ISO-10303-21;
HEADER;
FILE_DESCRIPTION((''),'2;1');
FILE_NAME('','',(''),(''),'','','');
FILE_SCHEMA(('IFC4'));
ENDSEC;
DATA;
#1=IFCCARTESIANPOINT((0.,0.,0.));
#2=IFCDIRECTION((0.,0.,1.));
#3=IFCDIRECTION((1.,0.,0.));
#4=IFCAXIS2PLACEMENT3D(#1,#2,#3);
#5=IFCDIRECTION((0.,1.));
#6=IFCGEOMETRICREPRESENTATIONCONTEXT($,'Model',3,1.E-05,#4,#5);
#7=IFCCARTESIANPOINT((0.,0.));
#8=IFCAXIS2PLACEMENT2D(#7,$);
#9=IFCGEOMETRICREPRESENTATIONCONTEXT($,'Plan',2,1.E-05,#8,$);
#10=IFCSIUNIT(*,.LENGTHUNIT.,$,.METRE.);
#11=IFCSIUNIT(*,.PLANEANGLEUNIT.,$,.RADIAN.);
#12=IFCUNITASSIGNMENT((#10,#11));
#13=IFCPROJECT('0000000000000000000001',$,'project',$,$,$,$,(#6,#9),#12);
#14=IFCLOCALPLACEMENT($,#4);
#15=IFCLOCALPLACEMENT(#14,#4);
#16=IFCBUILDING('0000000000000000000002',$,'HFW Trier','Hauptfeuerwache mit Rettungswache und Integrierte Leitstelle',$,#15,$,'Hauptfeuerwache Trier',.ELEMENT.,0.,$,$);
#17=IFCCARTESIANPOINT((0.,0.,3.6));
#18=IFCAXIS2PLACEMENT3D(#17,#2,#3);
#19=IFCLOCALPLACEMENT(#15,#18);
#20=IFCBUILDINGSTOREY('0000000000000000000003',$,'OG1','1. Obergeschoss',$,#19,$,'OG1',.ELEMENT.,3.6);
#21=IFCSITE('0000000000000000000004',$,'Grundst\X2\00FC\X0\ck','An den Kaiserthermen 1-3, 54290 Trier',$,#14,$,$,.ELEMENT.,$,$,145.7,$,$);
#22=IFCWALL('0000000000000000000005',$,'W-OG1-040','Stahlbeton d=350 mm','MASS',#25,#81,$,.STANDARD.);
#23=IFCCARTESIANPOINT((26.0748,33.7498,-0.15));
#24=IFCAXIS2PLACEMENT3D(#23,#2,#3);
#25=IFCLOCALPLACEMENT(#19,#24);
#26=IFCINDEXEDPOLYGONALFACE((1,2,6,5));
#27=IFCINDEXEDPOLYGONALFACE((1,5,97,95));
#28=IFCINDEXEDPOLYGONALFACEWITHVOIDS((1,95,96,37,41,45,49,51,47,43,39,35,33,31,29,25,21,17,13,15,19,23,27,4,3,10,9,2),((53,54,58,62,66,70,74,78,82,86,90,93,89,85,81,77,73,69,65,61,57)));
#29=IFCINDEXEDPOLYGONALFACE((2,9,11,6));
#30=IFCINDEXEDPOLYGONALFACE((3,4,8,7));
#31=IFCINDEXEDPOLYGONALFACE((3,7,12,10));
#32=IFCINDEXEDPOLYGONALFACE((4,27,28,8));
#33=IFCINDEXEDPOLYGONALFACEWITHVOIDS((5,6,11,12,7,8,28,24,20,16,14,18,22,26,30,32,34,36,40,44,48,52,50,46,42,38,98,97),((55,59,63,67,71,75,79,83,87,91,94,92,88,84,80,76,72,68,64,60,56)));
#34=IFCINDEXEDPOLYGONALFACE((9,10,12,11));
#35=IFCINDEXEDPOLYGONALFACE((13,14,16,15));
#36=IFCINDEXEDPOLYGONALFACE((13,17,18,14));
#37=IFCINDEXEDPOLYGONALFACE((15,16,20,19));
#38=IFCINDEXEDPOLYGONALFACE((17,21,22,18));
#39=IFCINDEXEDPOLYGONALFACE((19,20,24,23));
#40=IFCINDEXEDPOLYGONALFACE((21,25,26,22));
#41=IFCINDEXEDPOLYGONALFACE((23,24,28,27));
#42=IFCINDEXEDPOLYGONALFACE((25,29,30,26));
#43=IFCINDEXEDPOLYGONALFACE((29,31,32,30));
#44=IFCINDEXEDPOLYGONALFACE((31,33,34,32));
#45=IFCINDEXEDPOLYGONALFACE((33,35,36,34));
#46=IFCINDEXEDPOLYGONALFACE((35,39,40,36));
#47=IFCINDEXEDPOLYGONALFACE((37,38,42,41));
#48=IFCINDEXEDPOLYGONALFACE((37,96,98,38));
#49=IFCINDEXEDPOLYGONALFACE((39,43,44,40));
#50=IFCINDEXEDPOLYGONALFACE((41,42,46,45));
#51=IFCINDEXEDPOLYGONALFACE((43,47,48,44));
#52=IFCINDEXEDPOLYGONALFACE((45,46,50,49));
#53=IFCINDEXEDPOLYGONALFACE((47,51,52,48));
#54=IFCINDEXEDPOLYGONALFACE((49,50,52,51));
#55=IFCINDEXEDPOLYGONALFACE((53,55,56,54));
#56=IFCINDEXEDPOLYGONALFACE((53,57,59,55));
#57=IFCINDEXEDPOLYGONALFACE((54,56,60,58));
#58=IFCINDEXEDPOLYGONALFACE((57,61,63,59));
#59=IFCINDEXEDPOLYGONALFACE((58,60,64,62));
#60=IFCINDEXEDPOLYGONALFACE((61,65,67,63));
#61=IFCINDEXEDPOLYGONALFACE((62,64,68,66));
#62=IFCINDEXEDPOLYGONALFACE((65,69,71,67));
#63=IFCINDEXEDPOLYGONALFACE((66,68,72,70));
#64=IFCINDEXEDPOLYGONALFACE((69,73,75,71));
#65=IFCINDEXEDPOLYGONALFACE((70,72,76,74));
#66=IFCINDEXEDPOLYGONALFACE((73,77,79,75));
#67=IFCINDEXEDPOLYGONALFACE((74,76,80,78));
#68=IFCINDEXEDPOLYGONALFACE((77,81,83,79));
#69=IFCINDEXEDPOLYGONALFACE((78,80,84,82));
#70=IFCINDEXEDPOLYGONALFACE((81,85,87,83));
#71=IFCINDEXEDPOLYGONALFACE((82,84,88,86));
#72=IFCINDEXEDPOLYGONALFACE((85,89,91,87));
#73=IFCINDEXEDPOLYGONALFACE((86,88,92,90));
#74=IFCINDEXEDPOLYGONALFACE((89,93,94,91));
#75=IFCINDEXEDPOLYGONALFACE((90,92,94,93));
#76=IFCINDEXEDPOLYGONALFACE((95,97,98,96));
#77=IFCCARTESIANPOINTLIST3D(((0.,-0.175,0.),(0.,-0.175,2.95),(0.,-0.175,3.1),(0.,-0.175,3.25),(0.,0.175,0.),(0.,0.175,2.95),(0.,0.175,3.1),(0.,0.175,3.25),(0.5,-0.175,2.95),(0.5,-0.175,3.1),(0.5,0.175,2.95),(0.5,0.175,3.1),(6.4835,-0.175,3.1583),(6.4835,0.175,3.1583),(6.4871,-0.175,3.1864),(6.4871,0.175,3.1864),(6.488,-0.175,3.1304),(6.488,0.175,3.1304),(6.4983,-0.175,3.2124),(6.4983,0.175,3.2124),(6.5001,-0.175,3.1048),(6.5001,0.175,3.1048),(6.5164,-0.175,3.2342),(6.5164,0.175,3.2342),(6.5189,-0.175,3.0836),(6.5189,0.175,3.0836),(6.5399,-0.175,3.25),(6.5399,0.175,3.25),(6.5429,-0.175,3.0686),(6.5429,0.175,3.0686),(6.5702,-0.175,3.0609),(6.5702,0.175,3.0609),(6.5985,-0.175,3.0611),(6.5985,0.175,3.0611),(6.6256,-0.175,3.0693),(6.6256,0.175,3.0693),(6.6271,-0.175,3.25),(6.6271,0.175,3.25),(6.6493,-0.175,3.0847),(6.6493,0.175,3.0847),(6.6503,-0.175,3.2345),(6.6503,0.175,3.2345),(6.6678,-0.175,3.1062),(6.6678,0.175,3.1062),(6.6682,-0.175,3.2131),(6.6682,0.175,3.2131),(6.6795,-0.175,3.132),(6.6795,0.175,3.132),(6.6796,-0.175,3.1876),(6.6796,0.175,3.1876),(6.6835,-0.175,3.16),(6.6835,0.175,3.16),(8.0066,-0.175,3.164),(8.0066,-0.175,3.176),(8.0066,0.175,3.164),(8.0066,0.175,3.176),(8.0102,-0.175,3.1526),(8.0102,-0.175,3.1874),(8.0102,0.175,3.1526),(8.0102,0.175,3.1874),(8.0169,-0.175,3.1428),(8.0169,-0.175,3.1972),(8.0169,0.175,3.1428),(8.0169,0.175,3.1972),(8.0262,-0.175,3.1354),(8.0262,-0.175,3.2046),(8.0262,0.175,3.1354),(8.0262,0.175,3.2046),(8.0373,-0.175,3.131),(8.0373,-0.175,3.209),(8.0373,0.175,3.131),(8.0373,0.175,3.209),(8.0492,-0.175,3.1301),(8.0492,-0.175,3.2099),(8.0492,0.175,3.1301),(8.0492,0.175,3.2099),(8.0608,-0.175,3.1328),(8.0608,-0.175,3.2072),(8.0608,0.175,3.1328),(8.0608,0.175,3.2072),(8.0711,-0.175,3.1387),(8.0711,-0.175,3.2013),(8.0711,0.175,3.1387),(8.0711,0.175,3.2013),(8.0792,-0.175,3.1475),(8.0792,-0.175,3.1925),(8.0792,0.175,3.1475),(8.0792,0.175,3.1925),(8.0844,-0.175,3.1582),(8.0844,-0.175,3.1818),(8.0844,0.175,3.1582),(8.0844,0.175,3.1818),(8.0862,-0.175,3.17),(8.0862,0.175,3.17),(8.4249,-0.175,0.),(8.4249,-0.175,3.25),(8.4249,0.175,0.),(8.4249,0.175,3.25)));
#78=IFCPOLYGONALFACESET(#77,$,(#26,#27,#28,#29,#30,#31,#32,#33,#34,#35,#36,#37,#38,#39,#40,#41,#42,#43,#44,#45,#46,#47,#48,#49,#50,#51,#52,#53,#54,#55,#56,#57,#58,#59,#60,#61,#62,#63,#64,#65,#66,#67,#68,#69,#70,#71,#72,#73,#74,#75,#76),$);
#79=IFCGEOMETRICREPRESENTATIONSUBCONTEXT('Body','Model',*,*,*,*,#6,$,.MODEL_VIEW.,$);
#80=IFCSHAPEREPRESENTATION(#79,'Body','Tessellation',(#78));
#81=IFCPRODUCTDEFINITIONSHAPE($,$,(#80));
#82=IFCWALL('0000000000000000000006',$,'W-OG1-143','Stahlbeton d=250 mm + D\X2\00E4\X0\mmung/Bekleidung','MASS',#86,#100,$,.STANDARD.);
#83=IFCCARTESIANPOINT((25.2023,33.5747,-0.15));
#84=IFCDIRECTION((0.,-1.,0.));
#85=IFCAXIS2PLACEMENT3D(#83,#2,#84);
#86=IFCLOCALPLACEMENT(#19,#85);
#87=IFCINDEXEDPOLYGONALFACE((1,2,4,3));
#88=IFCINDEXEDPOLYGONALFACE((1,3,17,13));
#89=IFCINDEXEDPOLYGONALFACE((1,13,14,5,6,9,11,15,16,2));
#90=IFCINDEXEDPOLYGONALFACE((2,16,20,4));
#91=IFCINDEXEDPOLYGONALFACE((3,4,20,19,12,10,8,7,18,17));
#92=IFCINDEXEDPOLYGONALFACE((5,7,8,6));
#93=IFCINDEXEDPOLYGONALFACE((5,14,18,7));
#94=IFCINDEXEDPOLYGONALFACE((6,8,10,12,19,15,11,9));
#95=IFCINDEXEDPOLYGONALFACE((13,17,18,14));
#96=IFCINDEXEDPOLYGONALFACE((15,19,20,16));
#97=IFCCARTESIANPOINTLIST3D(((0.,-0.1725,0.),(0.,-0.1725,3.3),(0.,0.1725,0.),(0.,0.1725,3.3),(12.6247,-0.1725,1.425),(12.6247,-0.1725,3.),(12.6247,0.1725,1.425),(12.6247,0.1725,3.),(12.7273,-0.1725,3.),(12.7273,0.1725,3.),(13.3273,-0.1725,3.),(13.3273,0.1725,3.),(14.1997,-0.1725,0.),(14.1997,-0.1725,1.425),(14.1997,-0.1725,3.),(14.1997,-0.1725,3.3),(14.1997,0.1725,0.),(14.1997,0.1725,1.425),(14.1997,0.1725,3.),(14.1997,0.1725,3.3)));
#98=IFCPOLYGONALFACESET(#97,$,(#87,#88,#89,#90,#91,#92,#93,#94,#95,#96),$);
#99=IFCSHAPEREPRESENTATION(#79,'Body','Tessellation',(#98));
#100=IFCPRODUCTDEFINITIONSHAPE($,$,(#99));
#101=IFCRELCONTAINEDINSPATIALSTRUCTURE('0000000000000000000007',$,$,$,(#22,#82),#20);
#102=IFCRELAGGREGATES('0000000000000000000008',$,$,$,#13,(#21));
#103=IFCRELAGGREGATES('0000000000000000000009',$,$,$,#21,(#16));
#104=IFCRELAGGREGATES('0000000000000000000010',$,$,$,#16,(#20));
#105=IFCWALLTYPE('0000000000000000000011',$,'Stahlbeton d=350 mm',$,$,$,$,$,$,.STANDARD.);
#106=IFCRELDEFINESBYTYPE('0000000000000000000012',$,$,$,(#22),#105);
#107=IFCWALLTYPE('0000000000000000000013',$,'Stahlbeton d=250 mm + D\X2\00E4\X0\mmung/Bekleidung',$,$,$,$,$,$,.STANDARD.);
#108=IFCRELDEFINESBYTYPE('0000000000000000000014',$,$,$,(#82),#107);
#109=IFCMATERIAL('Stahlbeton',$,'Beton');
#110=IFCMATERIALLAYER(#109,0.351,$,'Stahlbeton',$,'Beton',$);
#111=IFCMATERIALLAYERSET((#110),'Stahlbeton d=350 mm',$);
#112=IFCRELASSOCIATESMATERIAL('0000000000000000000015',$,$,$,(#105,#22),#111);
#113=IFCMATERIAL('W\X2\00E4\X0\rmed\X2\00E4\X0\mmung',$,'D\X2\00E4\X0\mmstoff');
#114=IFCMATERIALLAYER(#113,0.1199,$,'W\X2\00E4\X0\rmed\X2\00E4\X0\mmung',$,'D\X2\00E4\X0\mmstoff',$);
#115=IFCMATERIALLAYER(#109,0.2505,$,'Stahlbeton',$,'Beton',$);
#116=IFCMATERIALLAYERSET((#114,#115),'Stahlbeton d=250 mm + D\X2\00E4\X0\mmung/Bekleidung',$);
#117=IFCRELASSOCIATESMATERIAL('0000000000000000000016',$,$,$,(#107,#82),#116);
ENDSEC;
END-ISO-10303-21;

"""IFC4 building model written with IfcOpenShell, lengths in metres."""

from ifc_helpers import new_model, si_unit, direction, frame, frame_2d, origin_with_axes, origin_2d, place, context, subcontext, project, spatial, rectangle, circle, extrude, material, layer, layer_set, layer_usage, type_object, element, save


model = new_model("IFC4")

# Units and contexts
model_context = context("Model", 3, precision=1e-05, world=origin_with_axes(), true_north=direction((0.0, 1.0)))
plan_context = context("Plan", 2, precision=1e-05, world=origin_2d())
body_context = subcontext(model_context, "Body", "Model", "MODEL_VIEW")
ifc_project = project(units=[si_unit("LENGTHUNIT", "METRE"), si_unit("PLANEANGLEUNIT", "RADIAN")], contexts=[model_context, plan_context])

# Site, building, storey
site_placement = place(None, origin_with_axes())
site = spatial("IfcSite", under=ifc_project, at=site_placement, Name="Grundstück", Description="An den Kaiserthermen 1-3, 54290 Trier", CompositionType="ELEMENT", RefElevation=145.7)
building_placement = place(site_placement, origin_with_axes())
building = spatial("IfcBuilding", under=site, at=building_placement, Name="HFW Trier", Description="Hauptfeuerwache mit Rettungswache und Integrierte Leitstelle", LongName="Hauptfeuerwache Trier", CompositionType="ELEMENT", ElevationOfRefHeight=0.0)
storey_placement = place(building_placement, frame((0.0, 0.0, 3.6), z_axis=(0.0, 0.0, 1.0), x_axis=(1.0, 0.0, 0.0)))
storey = spatial("IfcBuildingStorey", under=building, at=storey_placement, Name="OG1", Description="1. Obergeschoss", LongName="OG1", CompositionType="ELEMENT", Elevation=3.6)

# Shared definitions
ifc_material_1 = material(Name="Stahlbeton", Category="Beton")

# Walls, openings
ifc_layer_1 = layer(ifc_material_1, 0.351, Name="Stahlbeton", Category="Beton")
ifc_layer_set_1 = layer_set([ifc_layer_1], Name="Stahlbeton d=350 mm")
ifc_layer_usage_1 = layer_usage(ifc_layer_set_1, "AXIS2", "POSITIVE", -0.175)
wall_type_1 = type_object("IfcWallType", Name="Stahlbeton d=350 mm", PredefinedType="STANDARD", material=ifc_layer_set_1)
wall_1_placement = place(storey_placement, frame((26.0748, 33.7498, -0.15), z_axis=(0.0, 0.0, 1.0), x_axis=(1.0, 0.0, 0.0)))
wall_1 = element("IfcWall", 1, at=wall_1_placement, inside=storey, type_object=wall_type_1, material=ifc_layer_usage_1, Name="W-OG1-040", Description="Stahlbeton d=350 mm", ObjectType="MASS", PredefinedType="STANDARD", context=body_context, shape_type="SweptSolid", body=[
    extrude(rectangle(XDim=8.4249, YDim=0.35, at=frame_2d((4.2124, 0.0))), origin_with_axes(), (0.0, 0.0, 1.0), 3.25),
])
opening_1_placement = place(wall_1_placement, origin_with_axes())
element("IfcOpeningElement", 2, at=opening_1_placement, cuts=wall_1, ObjectType="Wanddurchbruch", PredefinedType="OPENING", context=body_context, shape_type="SweptSolid", body=[
    extrude(circle(Radius=0.04, at=origin_2d()), frame((8.0462, -0.225, 3.17), z_axis=(0.0, 1.0, 0.0), x_axis=(1.0, 0.0, 0.0)), (0.0, 0.0, 1.0), 0.45),
])
opening_2_placement = place(wall_1_placement, origin_with_axes())
element("IfcOpeningElement", 3, at=opening_2_placement, cuts=wall_1, ObjectType="Wanddurchbruch", PredefinedType="OPENING", context=body_context, shape_type="SweptSolid", body=[
    extrude(rectangle(XDim=0.5, YDim=0.45, at=frame_2d((0.25, 0.0))), frame((0.0, 0.0, 2.95), z_axis=(0.0, 0.0, 1.0), x_axis=(1.0, 0.0, 0.0)), (0.0, 0.0, 1.0), 0.15),
])
opening_3_placement = place(wall_1_placement, origin_with_axes())
element("IfcOpeningElement", 4, at=opening_3_placement, cuts=wall_1, ObjectType="Wanddurchbruch", PredefinedType="OPENING", context=body_context, shape_type="SweptSolid", body=[
    extrude(circle(Radius=0.1, at=origin_2d()), frame((6.5835, -0.225, 3.16), z_axis=(0.0, 1.0, 0.0), x_axis=(1.0, 0.0, 0.0)), (0.0, 0.0, 1.0), 0.45),
])
ifc_material_2 = material(Name="Wärmedämmung", Category="Dämmstoff")
ifc_layer_2 = layer(ifc_material_2, 0.1199, Name="Wärmedämmung", Category="Dämmstoff")
ifc_layer_3 = layer(ifc_material_1, 0.2505, Name="Stahlbeton", Category="Beton")
ifc_layer_set_2 = layer_set([ifc_layer_2, ifc_layer_3], Name="Stahlbeton d=250 mm + Dämmung/Bekleidung")
ifc_layer_usage_2 = layer_usage(ifc_layer_set_2, "AXIS2", "POSITIVE", -0.1724)
wall_type_2 = type_object("IfcWallType", Name="Stahlbeton d=250 mm + Dämmung/Bekleidung", PredefinedType="STANDARD", material=ifc_layer_set_2)
wall_2_placement = place(storey_placement, frame((25.2023, 33.5747, -0.15), z_axis=(0.0, 0.0, 1.0), x_axis=(0.0, -1.0, 0.0)))
wall_2 = element("IfcWall", 5, at=wall_2_placement, inside=storey, type_object=wall_type_2, material=ifc_layer_usage_2, Name="W-OG1-143", Description="Stahlbeton d=250 mm + Dämmung/Bekleidung", ObjectType="MASS", PredefinedType="STANDARD", context=body_context, shape_type="SweptSolid", body=[
    extrude(rectangle(XDim=14.1997, YDim=0.3449, at=frame_2d((7.0998, 0.0))), origin_with_axes(), (0.0, 0.0, 1.0), 3.3),
])
opening_4_placement = place(wall_2_placement, origin_with_axes())
element("IfcOpeningElement", 6, at=opening_4_placement, cuts=wall_2, ObjectType="Wanddurchbruch", PredefinedType="OPENING", context=body_context, shape_type="SweptSolid", body=[
    extrude(rectangle(XDim=1.575, YDim=0.4449, at=frame_2d((13.4122, 0.0))), frame((0.0, 0.0, 1.425), z_axis=(0.0, 0.0, 1.0), x_axis=(1.0, 0.0, 0.0)), (0.0, 0.0, 1.0), 1.575),
])
opening_5_placement = place(wall_2_placement, origin_with_axes())
element("IfcOpeningElement", 7, at=opening_5_placement, cuts=wall_2, ObjectType="Wanddurchbruch", PredefinedType="OPENING", context=body_context, shape_type="SweptSolid", body=[
    extrude(rectangle(XDim=0.6, YDim=0.4449, at=frame_2d((13.0273, 0.0))), frame((0.0, 0.0, 2.4), z_axis=(0.0, 0.0, 1.0), x_axis=(1.0, 0.0, 0.0)), (0.0, 0.0, 1.0), 0.6),
])

save(model, "model.ifc")
